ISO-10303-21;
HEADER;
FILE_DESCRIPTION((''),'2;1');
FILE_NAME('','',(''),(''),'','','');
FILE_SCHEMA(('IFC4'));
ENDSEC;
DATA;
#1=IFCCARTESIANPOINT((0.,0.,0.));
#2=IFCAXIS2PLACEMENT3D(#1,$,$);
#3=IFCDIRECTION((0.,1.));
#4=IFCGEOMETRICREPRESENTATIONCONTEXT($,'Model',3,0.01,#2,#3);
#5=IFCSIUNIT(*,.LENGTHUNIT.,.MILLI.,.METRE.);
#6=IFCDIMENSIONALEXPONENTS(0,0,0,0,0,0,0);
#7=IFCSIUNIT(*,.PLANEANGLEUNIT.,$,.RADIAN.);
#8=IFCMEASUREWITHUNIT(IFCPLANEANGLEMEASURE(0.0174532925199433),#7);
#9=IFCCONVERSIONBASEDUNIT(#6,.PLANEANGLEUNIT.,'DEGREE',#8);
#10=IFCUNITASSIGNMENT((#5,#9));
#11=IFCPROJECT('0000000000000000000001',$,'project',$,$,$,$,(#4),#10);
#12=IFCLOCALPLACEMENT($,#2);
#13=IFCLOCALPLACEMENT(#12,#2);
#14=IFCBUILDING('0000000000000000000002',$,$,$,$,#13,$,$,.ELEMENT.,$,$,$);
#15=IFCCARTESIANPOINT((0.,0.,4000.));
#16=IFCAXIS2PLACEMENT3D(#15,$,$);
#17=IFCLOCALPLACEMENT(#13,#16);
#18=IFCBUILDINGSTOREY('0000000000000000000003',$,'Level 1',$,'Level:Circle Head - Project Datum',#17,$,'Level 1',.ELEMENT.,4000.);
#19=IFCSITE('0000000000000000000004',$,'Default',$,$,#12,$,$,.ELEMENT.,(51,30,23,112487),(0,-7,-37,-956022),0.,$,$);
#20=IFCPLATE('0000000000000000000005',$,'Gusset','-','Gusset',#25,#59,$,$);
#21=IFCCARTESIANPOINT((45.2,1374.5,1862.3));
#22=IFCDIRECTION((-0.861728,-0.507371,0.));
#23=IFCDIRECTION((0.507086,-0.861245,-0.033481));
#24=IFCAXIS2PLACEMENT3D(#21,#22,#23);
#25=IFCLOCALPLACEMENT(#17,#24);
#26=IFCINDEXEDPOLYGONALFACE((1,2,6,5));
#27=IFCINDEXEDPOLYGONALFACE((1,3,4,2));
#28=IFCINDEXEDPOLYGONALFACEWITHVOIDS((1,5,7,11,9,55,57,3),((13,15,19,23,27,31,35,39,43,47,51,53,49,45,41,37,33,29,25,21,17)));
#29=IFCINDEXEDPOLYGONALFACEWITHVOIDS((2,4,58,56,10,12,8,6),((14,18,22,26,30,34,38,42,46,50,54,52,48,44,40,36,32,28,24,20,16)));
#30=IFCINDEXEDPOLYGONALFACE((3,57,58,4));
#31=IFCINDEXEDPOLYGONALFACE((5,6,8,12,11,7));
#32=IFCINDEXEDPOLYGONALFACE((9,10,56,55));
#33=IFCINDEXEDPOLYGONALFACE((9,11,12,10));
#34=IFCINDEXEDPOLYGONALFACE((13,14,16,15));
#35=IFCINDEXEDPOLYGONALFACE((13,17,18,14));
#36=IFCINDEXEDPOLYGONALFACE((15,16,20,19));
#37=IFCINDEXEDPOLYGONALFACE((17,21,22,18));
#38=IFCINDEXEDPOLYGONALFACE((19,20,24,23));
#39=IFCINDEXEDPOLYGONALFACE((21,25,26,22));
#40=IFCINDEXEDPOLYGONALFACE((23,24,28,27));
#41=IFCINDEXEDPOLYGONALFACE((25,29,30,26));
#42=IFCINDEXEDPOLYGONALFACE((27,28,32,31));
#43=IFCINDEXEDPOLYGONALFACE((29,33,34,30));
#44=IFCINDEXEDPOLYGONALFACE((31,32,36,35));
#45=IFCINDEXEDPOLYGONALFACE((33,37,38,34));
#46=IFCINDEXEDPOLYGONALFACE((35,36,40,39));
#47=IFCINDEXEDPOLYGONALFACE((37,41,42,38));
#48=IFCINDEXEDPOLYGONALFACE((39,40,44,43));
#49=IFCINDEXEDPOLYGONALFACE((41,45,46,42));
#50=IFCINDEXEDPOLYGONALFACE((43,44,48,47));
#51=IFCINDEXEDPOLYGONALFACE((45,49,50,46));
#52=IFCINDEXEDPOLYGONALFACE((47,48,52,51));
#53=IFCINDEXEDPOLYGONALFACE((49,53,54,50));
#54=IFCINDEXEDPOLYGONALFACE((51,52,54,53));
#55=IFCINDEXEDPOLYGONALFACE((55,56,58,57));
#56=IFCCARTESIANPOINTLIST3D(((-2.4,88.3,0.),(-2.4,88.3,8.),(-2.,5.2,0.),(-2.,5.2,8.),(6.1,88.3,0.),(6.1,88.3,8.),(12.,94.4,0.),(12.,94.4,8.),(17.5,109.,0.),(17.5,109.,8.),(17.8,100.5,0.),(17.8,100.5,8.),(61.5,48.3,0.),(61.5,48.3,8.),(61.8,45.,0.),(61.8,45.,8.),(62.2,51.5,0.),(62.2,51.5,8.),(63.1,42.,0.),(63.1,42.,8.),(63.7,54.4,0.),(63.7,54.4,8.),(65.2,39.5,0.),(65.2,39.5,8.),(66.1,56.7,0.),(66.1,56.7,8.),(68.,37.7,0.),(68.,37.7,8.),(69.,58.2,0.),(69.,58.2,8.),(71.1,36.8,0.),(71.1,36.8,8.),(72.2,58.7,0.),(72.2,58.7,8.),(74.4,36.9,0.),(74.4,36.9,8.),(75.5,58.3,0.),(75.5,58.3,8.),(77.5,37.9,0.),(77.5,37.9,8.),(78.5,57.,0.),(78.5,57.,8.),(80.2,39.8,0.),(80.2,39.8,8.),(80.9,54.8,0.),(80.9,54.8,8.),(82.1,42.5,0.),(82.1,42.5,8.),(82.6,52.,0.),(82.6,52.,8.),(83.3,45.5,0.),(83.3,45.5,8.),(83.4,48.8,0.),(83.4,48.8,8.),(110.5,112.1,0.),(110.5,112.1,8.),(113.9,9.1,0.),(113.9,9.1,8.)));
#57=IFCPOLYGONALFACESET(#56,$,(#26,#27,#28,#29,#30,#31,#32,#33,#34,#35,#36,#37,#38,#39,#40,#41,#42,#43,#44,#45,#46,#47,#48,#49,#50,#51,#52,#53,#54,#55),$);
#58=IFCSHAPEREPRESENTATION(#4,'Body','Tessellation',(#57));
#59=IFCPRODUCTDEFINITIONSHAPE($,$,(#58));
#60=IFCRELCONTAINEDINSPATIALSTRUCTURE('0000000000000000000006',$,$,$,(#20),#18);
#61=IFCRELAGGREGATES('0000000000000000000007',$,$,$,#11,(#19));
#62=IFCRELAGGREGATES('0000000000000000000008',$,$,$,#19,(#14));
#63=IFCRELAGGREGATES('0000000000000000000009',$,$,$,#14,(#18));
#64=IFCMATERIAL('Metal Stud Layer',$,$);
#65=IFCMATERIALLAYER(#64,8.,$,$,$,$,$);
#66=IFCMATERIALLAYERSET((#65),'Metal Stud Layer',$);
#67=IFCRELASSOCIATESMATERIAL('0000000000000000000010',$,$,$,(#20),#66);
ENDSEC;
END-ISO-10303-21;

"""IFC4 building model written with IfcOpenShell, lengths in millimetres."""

from ifc_helpers import new_model, entity, si_unit, converted_unit, point, direction, frame, frame_2d, origin, origin_with_axes, origin_2d_with_axis, place, context, project, spatial, polyline, circle_curve, line_curve, trimmed, segment, composite_curve, circle, outline, extrude, material, layer, layer_set, element, save


model = new_model("IFC4")

# Units and contexts
model_context = context("Model", 3, precision=0.01, world=origin(), true_north=direction((0.0, 1.0)))
ifc_project = project(units=[si_unit("LENGTHUNIT", "METRE", prefix="MILLI"), converted_unit("PLANEANGLEUNIT", "DEGREE", entity("IfcPlaneAngleMeasure", 0.0174532925199433), si_unit("PLANEANGLEUNIT", "RADIAN"), dimensions=[0, 0, 0, 0, 0, 0, 0])], contexts=[model_context])

# Site, building, storey
site_placement = place(None, origin())
site = spatial("IfcSite", under=ifc_project, at=site_placement, Name="Default", CompositionType="ELEMENT", RefLatitude=(51, 30, 23, 112487), RefLongitude=(0, -7, -37, -956022), RefElevation=0.0)
building_placement = place(site_placement, origin())
building = spatial("IfcBuilding", under=site, at=building_placement, CompositionType="ELEMENT")
storey_placement = place(building_placement, frame((0.0, 0.0, 4000.0)))
storey = spatial("IfcBuildingStorey", under=building, at=storey_placement, Name="Level 1", ObjectType="Level:Circle Head - Project Datum", LongName="Level 1", CompositionType="ELEMENT", Elevation=4000.0)

# Plate, openings
ifc_material_1 = material(Name="Metal Stud Layer")
ifc_layer_1 = layer(ifc_material_1, 8.0)
ifc_layer_set_1 = layer_set([ifc_layer_1], Name="Metal Stud Layer")
plate_1_placement = place(storey_placement, frame((45.2, 1374.5, 1862.3), z_axis=(-0.861728, -0.507371, 0.0), x_axis=(0.507086, -0.861245, -0.033481)))
plate_1 = element("IfcPlate", 1, at=plate_1_placement, inside=storey, material=ifc_layer_set_1, Name="Gusset", Description="-", ObjectType="Gusset", context=model_context, shape_type="SweptSolid", body=[
    extrude(outline(polyline([(-2.0, 5.2), (113.9, 9.1), (110.5, 112.1), (17.5, 109.0), (17.8, 100.5), (6.1, 88.3), (-2.4, 88.3), (-2.0, 5.2)])), origin_with_axes(), (0.0, 0.0, 1.0), 8.0),
])
opening_1_placement = place(plate_1_placement, origin_with_axes())
element("IfcOpeningElement", 2, at=opening_1_placement, cuts=plate_1, ObjectType="Opening", context=model_context, shape_type="SweptSolid", body=[
    extrude(outline(composite_curve([segment(trimmed(line_curve((17.8, 100.5), (-0.693597, -0.720363), 8.455359), [point((17.8, 100.5))], [point((12.0, 94.4))], True, "CARTESIAN"), True, "CONTINUOUS"), segment(trimmed(circle_curve(frame_2d((-2.4, 108.3), x_axis=(1.0, 0.0)), 20.0), [point((12.0, 94.4))], [point((17.5, 109.0))], True, "CARTESIAN"), True, "CONTINUOUS"), segment(trimmed(line_curve((17.5, 109.0), (0.033481, -0.999439), 8.455359), [point((17.5, 109.0))], [point((17.8, 100.5))], True, "CARTESIAN"), True, "CONTINUOUS")], self_intersect="UNKNOWN")), origin(), (0.0, 0.0, 1.0), 8.0),
])
opening_2_placement = place(plate_1_placement, origin_with_axes())
element("IfcOpeningElement", 3, at=opening_2_placement, cuts=plate_1, ObjectType="Opening", context=model_context, shape_type="SweptSolid", body=[
    extrude(outline(composite_curve([segment(trimmed(line_curve((6.1, 88.3), (-0.99999, -0.004369), 8.455359), [point((6.1, 88.3))], [point((-2.4, 88.3))], True, "CARTESIAN"), True, "CONTINUOUS"), segment(trimmed(circle_curve(frame_2d((-2.4, 108.3), x_axis=(1.0, 0.0)), 20.0), [point((-2.4, 88.3))], [point((12.0, 94.4))], True, "CARTESIAN"), True, "CONTINUOUS"), segment(trimmed(line_curve((12.0, 94.4), (-0.693597, -0.720363), 8.455359), [point((12.0, 94.4))], [point((6.1, 88.3))], True, "CARTESIAN"), True, "CONTINUOUS")], self_intersect="UNKNOWN")), origin(), (0.0, 0.0, 1.0), 8.0),
])
opening_3_placement = place(plate_1_placement, frame((72.5, 47.7, -0.5), z_axis=(0.0, 0.0, 1.0), x_axis=(0.8774, -0.47976, 0.0)))
element("IfcOpeningElement", 4, at=opening_3_placement, cuts=plate_1, ObjectType="Opening", context=model_context, shape_type="SweptSolid", body=[
    extrude(circle(Radius=11.0, at=origin_2d_with_axis()), origin(), (0.0, 0.0, 1.0), 9.0),
])

save(model, "model.ifc")
